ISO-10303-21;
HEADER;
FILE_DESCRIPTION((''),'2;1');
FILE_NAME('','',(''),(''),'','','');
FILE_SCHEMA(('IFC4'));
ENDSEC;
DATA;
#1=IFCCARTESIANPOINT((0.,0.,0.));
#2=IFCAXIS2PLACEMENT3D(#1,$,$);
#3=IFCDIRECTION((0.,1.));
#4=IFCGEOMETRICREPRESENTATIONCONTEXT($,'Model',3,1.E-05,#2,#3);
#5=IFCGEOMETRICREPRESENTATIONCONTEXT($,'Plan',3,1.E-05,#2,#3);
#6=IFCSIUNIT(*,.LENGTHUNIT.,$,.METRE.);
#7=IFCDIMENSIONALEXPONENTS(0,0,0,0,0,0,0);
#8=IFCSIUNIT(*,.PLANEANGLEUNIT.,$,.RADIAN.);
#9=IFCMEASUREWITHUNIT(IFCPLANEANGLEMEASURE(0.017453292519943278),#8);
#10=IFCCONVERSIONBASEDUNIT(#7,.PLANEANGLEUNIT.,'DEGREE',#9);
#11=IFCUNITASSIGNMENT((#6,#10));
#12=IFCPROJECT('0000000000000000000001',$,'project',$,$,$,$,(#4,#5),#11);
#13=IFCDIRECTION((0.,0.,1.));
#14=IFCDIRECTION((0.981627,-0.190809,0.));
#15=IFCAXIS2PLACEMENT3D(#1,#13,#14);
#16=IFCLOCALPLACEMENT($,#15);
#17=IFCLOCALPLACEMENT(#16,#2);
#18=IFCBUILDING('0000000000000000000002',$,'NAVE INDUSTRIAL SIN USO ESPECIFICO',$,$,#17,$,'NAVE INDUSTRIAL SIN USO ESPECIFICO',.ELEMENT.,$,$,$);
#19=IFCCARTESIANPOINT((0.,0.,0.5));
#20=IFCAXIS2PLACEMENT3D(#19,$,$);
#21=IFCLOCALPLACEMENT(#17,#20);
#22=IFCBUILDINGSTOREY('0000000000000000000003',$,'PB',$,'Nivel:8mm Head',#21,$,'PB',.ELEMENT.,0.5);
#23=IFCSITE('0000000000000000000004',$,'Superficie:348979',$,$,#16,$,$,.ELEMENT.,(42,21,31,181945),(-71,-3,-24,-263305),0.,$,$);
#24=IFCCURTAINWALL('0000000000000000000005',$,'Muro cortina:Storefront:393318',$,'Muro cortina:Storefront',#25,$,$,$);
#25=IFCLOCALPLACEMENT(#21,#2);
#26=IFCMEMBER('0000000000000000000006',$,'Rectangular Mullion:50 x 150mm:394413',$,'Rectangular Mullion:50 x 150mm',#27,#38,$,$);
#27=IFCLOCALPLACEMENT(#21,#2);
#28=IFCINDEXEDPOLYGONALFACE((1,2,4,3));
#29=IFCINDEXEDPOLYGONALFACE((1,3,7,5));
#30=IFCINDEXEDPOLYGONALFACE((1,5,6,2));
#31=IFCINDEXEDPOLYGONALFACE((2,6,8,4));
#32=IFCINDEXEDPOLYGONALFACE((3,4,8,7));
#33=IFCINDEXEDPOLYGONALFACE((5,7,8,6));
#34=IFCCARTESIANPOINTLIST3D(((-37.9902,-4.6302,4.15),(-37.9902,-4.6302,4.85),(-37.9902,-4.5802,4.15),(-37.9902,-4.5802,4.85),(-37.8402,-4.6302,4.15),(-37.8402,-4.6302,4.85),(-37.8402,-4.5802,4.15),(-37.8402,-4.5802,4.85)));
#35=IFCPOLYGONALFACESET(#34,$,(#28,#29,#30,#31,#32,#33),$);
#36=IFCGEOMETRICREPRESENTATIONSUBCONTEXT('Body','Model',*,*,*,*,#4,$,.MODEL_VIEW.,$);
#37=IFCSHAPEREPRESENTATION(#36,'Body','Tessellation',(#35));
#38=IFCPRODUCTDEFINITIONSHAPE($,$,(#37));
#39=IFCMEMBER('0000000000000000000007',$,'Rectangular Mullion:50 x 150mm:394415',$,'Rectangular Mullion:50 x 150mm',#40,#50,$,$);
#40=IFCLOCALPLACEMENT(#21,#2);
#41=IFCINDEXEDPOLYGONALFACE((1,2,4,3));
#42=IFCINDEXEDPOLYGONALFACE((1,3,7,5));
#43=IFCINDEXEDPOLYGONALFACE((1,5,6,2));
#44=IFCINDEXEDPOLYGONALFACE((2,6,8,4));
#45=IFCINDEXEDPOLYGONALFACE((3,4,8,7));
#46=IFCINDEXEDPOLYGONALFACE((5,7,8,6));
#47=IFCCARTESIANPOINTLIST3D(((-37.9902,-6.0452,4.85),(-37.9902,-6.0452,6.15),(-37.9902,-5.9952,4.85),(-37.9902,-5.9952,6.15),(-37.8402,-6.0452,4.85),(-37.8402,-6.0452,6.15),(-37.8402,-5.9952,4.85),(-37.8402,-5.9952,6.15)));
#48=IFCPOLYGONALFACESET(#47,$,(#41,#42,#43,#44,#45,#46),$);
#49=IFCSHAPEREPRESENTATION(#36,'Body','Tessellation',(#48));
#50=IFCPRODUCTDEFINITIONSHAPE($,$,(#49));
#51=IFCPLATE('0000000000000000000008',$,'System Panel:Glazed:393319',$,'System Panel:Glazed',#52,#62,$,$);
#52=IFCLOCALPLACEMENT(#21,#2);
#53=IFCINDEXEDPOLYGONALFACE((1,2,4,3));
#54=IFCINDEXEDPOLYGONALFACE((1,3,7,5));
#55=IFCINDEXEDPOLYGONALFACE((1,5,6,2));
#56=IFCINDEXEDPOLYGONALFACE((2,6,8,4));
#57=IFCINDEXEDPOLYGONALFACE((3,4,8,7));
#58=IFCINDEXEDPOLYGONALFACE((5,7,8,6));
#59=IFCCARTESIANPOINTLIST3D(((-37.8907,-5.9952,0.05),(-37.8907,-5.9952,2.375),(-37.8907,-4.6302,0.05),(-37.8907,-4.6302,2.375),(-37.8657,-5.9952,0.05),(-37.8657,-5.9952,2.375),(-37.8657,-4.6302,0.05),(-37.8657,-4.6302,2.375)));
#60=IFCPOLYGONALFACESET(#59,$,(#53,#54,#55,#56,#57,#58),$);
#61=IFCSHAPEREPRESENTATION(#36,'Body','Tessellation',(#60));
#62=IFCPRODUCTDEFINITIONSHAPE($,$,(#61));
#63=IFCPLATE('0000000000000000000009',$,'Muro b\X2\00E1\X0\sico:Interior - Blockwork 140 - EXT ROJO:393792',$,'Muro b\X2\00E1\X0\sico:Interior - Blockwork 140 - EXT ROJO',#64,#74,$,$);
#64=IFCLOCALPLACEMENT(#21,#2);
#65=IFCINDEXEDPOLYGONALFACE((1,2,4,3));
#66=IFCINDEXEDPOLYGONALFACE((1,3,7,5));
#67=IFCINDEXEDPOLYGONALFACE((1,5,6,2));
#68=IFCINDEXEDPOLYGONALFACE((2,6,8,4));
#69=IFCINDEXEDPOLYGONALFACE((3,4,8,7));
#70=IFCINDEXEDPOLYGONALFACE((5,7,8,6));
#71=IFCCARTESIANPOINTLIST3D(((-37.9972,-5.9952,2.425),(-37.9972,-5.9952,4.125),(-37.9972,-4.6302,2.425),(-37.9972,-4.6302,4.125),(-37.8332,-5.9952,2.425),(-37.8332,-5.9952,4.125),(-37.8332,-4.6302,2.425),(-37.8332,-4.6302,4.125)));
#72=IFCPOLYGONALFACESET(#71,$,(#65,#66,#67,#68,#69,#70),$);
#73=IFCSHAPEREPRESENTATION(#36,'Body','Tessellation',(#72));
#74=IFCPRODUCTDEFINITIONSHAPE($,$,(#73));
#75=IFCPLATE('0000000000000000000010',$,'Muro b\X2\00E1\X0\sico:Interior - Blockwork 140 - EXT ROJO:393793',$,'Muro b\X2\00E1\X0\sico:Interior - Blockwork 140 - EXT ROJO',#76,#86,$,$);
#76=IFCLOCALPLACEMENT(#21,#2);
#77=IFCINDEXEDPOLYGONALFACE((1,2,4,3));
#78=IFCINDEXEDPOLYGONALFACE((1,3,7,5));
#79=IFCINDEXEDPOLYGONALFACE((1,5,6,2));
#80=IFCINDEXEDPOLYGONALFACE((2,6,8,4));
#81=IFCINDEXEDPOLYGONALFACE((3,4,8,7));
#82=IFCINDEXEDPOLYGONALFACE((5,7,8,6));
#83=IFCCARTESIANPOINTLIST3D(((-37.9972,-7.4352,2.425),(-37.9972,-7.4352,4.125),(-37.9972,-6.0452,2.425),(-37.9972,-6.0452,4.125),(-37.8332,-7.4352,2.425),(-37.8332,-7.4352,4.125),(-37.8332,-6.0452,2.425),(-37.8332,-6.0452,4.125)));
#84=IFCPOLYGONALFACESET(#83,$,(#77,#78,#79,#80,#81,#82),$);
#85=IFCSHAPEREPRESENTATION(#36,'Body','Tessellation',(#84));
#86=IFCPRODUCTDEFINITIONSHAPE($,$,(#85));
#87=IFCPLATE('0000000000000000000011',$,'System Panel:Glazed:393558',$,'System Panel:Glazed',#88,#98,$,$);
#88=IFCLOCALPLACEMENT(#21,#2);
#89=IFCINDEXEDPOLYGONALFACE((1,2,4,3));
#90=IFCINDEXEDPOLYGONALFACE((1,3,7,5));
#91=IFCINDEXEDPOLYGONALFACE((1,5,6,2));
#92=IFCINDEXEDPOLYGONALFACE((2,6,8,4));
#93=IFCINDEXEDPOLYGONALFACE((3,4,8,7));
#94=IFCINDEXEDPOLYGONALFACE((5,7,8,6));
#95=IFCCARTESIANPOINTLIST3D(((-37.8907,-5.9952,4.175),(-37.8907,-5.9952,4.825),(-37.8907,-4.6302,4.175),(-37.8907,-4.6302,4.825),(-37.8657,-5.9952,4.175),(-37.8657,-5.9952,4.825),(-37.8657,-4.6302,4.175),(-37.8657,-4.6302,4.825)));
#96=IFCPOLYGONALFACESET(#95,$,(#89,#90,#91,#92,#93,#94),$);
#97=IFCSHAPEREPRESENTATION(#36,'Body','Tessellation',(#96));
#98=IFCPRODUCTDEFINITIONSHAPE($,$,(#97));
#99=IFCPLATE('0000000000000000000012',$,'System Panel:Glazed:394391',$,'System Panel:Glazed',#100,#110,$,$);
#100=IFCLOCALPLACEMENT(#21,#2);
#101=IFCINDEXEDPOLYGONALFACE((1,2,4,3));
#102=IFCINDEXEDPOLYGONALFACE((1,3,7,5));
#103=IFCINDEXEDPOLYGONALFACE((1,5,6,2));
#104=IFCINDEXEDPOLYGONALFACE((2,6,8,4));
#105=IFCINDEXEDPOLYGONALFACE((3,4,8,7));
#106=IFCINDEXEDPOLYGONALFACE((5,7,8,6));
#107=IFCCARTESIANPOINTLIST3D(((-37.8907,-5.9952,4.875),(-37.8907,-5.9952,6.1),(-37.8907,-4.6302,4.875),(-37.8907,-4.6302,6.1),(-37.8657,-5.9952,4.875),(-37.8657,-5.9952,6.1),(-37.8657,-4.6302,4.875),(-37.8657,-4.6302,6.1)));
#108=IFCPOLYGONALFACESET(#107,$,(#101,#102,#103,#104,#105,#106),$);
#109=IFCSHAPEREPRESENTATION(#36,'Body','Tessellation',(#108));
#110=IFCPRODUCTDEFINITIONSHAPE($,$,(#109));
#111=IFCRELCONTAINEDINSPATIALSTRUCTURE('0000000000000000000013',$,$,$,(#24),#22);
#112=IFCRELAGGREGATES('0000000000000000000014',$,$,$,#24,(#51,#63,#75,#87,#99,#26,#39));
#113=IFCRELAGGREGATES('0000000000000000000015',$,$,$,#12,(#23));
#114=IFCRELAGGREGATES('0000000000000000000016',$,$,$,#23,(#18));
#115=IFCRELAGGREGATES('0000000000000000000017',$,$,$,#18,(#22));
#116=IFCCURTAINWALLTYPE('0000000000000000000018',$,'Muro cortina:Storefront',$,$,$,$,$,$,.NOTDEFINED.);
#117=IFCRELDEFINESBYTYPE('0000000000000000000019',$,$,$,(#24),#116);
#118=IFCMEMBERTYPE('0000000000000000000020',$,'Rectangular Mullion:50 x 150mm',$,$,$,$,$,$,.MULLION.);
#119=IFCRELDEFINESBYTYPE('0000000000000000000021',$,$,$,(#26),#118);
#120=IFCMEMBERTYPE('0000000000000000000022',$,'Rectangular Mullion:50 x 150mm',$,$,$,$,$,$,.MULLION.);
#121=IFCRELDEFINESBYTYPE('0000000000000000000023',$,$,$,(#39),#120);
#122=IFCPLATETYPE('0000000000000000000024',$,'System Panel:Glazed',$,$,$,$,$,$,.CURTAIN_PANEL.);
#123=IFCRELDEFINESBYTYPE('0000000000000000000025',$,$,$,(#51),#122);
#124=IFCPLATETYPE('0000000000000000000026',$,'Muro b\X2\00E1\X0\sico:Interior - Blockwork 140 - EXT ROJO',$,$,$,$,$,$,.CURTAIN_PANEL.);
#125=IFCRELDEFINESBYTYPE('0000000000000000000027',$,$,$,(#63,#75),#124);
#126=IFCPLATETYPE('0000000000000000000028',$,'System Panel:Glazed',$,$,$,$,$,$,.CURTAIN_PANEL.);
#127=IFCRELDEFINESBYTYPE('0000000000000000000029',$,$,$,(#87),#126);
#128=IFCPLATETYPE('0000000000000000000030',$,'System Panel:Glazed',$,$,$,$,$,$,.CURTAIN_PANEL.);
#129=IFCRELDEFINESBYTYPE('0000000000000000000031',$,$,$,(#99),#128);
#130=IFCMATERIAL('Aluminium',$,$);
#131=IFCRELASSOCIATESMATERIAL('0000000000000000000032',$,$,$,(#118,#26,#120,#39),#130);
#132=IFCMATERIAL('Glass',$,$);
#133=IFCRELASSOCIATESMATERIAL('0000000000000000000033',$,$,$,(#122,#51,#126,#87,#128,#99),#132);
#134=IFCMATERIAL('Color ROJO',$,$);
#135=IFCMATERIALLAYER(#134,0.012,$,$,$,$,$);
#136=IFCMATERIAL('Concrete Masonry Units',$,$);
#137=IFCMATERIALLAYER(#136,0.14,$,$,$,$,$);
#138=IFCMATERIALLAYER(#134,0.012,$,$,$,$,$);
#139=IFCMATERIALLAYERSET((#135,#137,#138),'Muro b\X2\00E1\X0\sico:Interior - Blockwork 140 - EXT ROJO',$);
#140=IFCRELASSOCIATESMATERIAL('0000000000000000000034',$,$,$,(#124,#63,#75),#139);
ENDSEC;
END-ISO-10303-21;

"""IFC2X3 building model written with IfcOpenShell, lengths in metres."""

from ifc_helpers import new_model, entity, si_unit, converted_unit, direction, frame, frame_2d, origin, origin_2d_with_axis, place, context, subcontext, project, spatial, rectangle, extrude, source, transform, mapped, material, layer, layer_set, layer_usage, type_object, type_shapes, element, aggregate, save


model = new_model("IFC2X3")

# Units and contexts
model_context = context("Model", 3, precision=1e-05, world=origin(), true_north=direction((0.0, 1.0)))
plan_context = context("Plan", 3, precision=1e-05, world=origin(), true_north=direction((0.0, 1.0)))
body_context = subcontext(model_context, "Body", "Model", "MODEL_VIEW")
ifc_project = project(units=[si_unit("LENGTHUNIT", "METRE"), converted_unit("PLANEANGLEUNIT", "DEGREE", entity("IfcPlaneAngleMeasure", 0.017453292519943278), si_unit("PLANEANGLEUNIT", "RADIAN"), dimensions=[0, 0, 0, 0, 0, 0, 0])], contexts=[model_context, plan_context])

# Site, building, storey
site_placement = place(None, frame((0.0, 0.0, 0.0), z_axis=(0.0, 0.0, 1.0), x_axis=(0.981627, -0.190809, 0.0)))
site = spatial("IfcSite", under=ifc_project, at=site_placement, Name="Superficie:348979", CompositionType="ELEMENT", RefLatitude=(42, 21, 31, 181945), RefLongitude=(-71, -3, -24, -263305), RefElevation=0.0)
building_placement = place(site_placement, origin())
building = spatial("IfcBuilding", under=site, at=building_placement, Name="NAVE INDUSTRIAL SIN USO ESPECIFICO", LongName="NAVE INDUSTRIAL SIN USO ESPECIFICO", CompositionType="ELEMENT")
storey_placement = place(building_placement, frame((0.0, 0.0, 0.5)))
storey = spatial("IfcBuildingStorey", under=building, at=storey_placement, Name="PB", ObjectType="Nivel:8mm Head", LongName="PB", CompositionType="ELEMENT", Elevation=0.5)

# Curtain wall, members, plates
curtain_wall_type = type_object("IfcCurtainWallType", Name="Muro cortina:Storefront", PredefinedType="NOTDEFINED")
curtain_wall_placement = place(storey_placement, frame((0.0, 0.0, -0.5)))
curtain_wall = element("IfcCurtainWall", 1, at=curtain_wall_placement, inside=storey, type_object=curtain_wall_type, Name="Muro cortina:Storefront:393318", ObjectType="Muro cortina:Storefront")
ifc_material_1 = material(Name="Aluminium")
member_type_1 = type_object("IfcMemberType", Name="Rectangular Mullion:50 x 150mm", PredefinedType="MULLION", material=ifc_material_1)
shared_shape_1 = source(origin(), body_context, "Body", "SweptSolid", [
    extrude(rectangle(XDim=0.05, YDim=0.15, at=origin_2d_with_axis()), frame((-0.025, 0.0, -0.7), z_axis=(0.0, 0.0, 1.0), x_axis=(-1.0, 0.0, 0.0)), (0.0, 0.0, 1.0), 0.7),
])
type_shapes(member_type_1, [shared_shape_1])
member_1_placement = place(curtain_wall_placement, frame((-37.9152, -4.5802, 5.35), z_axis=(0.0, 0.0, 1.0), x_axis=(0.0, 1.0, 0.0)))
member_1 = element("IfcMember", 2, at=member_1_placement, type_object=member_type_1, material=ifc_material_1, Name="Rectangular Mullion:50 x 150mm:394413", ObjectType="Rectangular Mullion:50 x 150mm", context=body_context, shape_type="MappedRepresentation", body=[
    mapped(shared_shape_1, transform((0.0, 0.0, 0.0), scale=1.0)),
])
member_type_2 = type_object("IfcMemberType", Name="Rectangular Mullion:50 x 150mm", PredefinedType="MULLION", material=ifc_material_1)
shared_shape_2 = source(origin(), body_context, "Body", "SweptSolid", [
    extrude(rectangle(XDim=0.05, YDim=0.15, at=origin_2d_with_axis()), frame((0.0, 0.0, -1.3), z_axis=(0.0, 0.0, 1.0), x_axis=(-1.0, 0.0, 0.0)), (0.0, 0.0, 1.0), 1.3),
])
type_shapes(member_type_2, [shared_shape_2])
member_2_placement = place(curtain_wall_placement, frame((-37.9152, -6.0202, 5.35), z_axis=(0.0, 0.0, -1.0), x_axis=(0.0, -1.0, 0.0)))
member_2 = element("IfcMember", 3, at=member_2_placement, type_object=member_type_2, material=ifc_material_1, Name="Rectangular Mullion:50 x 150mm:394415", ObjectType="Rectangular Mullion:50 x 150mm", context=body_context, shape_type="MappedRepresentation", body=[
    mapped(shared_shape_2, transform((0.0, 0.0, 0.0), scale=1.0)),
])
ifc_material_2 = material(Name="Glass")
plate_type_1 = type_object("IfcPlateType", Name="System Panel:Glazed", PredefinedType="CURTAIN_PANEL", material=ifc_material_2)
shared_shape_3 = source(origin(), body_context, "Body", "SweptSolid", [
    extrude(rectangle(XDim=0.025, YDim=1.365, at=origin_2d_with_axis()), frame((0.6825, 0.0125, 0.0), z_axis=(0.0, 0.0, 1.0), x_axis=(0.0, 1.0, 0.0)), (0.0, 0.0, 1.0), 2.325),
])
type_shapes(plate_type_1, [shared_shape_3])
plate_1_placement = place(curtain_wall_placement, frame((-37.8907, -4.6302, 0.55), z_axis=(0.0, 0.0, 1.0), x_axis=(0.0, -1.0, 0.0)))
plate_1 = element("IfcPlate", 4, at=plate_1_placement, type_object=plate_type_1, material=ifc_material_2, Name="System Panel:Glazed:393319", ObjectType="System Panel:Glazed", context=body_context, shape_type="MappedRepresentation", body=[
    mapped(shared_shape_3, transform((0.0, 0.0, 0.0), scale=1.0)),
])
ifc_material_3 = material(Name="Color ROJO")
ifc_layer_1 = layer(ifc_material_3, 0.012)
ifc_material_4 = material(Name="Concrete Masonry Units")
ifc_layer_2 = layer(ifc_material_4, 0.14)
ifc_layer_3 = layer(ifc_material_3, 0.012)
ifc_layer_set_1 = layer_set([ifc_layer_1, ifc_layer_2, ifc_layer_3], Name="Muro básico:Interior - Blockwork 140 - EXT ROJO")
ifc_layer_usage_1 = layer_usage(ifc_layer_set_1, "AXIS2", "NEGATIVE", 0.082)
plate_type_2 = type_object("IfcPlateType", Name="Muro básico:Interior - Blockwork 140 - EXT ROJO", PredefinedType="CURTAIN_PANEL", material=ifc_layer_set_1)
plate_2_placement = place(storey_placement, frame((-37.9152, -4.6302, 2.425), z_axis=(0.0, 0.0, 1.0), x_axis=(0.0, -1.0, 0.0)))
plate_2 = element("IfcPlate", 5, at=plate_2_placement, type_object=plate_type_2, material=ifc_layer_usage_1, Name="Muro básico:Interior - Blockwork 140 - EXT ROJO:393792", ObjectType="Muro básico:Interior - Blockwork 140 - EXT ROJO", context=body_context, shape_type="SweptSolid", body=[
    extrude(rectangle(XDim=0.164, YDim=1.365, at=frame_2d((0.0, 0.0), x_axis=(1.0, 0.0))), frame((0.6825, 0.0, 0.0), z_axis=(0.0, 0.0, 1.0), x_axis=(0.0, 1.0, 0.0)), (0.0, 0.0, 1.0), 1.7),
])
ifc_layer_usage_2 = layer_usage(ifc_layer_set_1, "AXIS2", "NEGATIVE", 0.082)
plate_3_placement = place(storey_placement, frame((-37.9152, -6.0452, 2.425), z_axis=(0.0, 0.0, 1.0), x_axis=(0.0, -1.0, 0.0)))
plate_3 = element("IfcPlate", 6, at=plate_3_placement, type_object=plate_type_2, material=ifc_layer_usage_2, Name="Muro básico:Interior - Blockwork 140 - EXT ROJO:393793", ObjectType="Muro básico:Interior - Blockwork 140 - EXT ROJO", context=body_context, shape_type="SweptSolid", body=[
    extrude(rectangle(XDim=0.164, YDim=1.39, at=frame_2d((0.0, 0.0), x_axis=(1.0, 0.0))), frame((0.695, 0.0, 0.0), z_axis=(0.0, 0.0, 1.0), x_axis=(0.0, 1.0, 0.0)), (0.0, 0.0, 1.0), 1.7),
])
plate_type_3 = type_object("IfcPlateType", Name="System Panel:Glazed", PredefinedType="CURTAIN_PANEL", material=ifc_material_2)
shared_shape_4 = source(origin(), body_context, "Body", "SweptSolid", [
    extrude(rectangle(XDim=0.025, YDim=1.365, at=origin_2d_with_axis()), frame((0.6825, 0.0125, 0.0), z_axis=(0.0, 0.0, 1.0), x_axis=(0.0, 1.0, 0.0)), (0.0, 0.0, 1.0), 0.65),
])
type_shapes(plate_type_3, [shared_shape_4])
plate_4_placement = place(curtain_wall_placement, frame((-37.8907, -4.6302, 4.675), z_axis=(0.0, 0.0, 1.0), x_axis=(0.0, -1.0, 0.0)))
plate_4 = element("IfcPlate", 7, at=plate_4_placement, type_object=plate_type_3, material=ifc_material_2, Name="System Panel:Glazed:393558", ObjectType="System Panel:Glazed", context=body_context, shape_type="MappedRepresentation", body=[
    mapped(shared_shape_4, transform((0.0, 0.0, 0.0), scale=1.0)),
])
plate_type_4 = type_object("IfcPlateType", Name="System Panel:Glazed", PredefinedType="CURTAIN_PANEL", material=ifc_material_2)
shared_shape_5 = source(origin(), body_context, "Body", "SweptSolid", [
    extrude(rectangle(XDim=0.025, YDim=1.365, at=origin_2d_with_axis()), frame((0.6825, 0.0125, 0.0), z_axis=(0.0, 0.0, 1.0), x_axis=(0.0, 1.0, 0.0)), (0.0, 0.0, 1.0), 1.225),
])
type_shapes(plate_type_4, [shared_shape_5])
plate_5_placement = place(curtain_wall_placement, frame((-37.8907, -4.6302, 5.375), z_axis=(0.0, 0.0, 1.0), x_axis=(0.0, -1.0, 0.0)))
plate_5 = element("IfcPlate", 8, at=plate_5_placement, type_object=plate_type_4, material=ifc_material_2, Name="System Panel:Glazed:394391", ObjectType="System Panel:Glazed", context=body_context, shape_type="MappedRepresentation", body=[
    mapped(shared_shape_5, transform((0.0, 0.0, 0.0), scale=1.0)),
])
aggregate(curtain_wall, [plate_1, plate_2, plate_3, plate_4, plate_5, member_1, member_2])

save(model, "model.ifc")
